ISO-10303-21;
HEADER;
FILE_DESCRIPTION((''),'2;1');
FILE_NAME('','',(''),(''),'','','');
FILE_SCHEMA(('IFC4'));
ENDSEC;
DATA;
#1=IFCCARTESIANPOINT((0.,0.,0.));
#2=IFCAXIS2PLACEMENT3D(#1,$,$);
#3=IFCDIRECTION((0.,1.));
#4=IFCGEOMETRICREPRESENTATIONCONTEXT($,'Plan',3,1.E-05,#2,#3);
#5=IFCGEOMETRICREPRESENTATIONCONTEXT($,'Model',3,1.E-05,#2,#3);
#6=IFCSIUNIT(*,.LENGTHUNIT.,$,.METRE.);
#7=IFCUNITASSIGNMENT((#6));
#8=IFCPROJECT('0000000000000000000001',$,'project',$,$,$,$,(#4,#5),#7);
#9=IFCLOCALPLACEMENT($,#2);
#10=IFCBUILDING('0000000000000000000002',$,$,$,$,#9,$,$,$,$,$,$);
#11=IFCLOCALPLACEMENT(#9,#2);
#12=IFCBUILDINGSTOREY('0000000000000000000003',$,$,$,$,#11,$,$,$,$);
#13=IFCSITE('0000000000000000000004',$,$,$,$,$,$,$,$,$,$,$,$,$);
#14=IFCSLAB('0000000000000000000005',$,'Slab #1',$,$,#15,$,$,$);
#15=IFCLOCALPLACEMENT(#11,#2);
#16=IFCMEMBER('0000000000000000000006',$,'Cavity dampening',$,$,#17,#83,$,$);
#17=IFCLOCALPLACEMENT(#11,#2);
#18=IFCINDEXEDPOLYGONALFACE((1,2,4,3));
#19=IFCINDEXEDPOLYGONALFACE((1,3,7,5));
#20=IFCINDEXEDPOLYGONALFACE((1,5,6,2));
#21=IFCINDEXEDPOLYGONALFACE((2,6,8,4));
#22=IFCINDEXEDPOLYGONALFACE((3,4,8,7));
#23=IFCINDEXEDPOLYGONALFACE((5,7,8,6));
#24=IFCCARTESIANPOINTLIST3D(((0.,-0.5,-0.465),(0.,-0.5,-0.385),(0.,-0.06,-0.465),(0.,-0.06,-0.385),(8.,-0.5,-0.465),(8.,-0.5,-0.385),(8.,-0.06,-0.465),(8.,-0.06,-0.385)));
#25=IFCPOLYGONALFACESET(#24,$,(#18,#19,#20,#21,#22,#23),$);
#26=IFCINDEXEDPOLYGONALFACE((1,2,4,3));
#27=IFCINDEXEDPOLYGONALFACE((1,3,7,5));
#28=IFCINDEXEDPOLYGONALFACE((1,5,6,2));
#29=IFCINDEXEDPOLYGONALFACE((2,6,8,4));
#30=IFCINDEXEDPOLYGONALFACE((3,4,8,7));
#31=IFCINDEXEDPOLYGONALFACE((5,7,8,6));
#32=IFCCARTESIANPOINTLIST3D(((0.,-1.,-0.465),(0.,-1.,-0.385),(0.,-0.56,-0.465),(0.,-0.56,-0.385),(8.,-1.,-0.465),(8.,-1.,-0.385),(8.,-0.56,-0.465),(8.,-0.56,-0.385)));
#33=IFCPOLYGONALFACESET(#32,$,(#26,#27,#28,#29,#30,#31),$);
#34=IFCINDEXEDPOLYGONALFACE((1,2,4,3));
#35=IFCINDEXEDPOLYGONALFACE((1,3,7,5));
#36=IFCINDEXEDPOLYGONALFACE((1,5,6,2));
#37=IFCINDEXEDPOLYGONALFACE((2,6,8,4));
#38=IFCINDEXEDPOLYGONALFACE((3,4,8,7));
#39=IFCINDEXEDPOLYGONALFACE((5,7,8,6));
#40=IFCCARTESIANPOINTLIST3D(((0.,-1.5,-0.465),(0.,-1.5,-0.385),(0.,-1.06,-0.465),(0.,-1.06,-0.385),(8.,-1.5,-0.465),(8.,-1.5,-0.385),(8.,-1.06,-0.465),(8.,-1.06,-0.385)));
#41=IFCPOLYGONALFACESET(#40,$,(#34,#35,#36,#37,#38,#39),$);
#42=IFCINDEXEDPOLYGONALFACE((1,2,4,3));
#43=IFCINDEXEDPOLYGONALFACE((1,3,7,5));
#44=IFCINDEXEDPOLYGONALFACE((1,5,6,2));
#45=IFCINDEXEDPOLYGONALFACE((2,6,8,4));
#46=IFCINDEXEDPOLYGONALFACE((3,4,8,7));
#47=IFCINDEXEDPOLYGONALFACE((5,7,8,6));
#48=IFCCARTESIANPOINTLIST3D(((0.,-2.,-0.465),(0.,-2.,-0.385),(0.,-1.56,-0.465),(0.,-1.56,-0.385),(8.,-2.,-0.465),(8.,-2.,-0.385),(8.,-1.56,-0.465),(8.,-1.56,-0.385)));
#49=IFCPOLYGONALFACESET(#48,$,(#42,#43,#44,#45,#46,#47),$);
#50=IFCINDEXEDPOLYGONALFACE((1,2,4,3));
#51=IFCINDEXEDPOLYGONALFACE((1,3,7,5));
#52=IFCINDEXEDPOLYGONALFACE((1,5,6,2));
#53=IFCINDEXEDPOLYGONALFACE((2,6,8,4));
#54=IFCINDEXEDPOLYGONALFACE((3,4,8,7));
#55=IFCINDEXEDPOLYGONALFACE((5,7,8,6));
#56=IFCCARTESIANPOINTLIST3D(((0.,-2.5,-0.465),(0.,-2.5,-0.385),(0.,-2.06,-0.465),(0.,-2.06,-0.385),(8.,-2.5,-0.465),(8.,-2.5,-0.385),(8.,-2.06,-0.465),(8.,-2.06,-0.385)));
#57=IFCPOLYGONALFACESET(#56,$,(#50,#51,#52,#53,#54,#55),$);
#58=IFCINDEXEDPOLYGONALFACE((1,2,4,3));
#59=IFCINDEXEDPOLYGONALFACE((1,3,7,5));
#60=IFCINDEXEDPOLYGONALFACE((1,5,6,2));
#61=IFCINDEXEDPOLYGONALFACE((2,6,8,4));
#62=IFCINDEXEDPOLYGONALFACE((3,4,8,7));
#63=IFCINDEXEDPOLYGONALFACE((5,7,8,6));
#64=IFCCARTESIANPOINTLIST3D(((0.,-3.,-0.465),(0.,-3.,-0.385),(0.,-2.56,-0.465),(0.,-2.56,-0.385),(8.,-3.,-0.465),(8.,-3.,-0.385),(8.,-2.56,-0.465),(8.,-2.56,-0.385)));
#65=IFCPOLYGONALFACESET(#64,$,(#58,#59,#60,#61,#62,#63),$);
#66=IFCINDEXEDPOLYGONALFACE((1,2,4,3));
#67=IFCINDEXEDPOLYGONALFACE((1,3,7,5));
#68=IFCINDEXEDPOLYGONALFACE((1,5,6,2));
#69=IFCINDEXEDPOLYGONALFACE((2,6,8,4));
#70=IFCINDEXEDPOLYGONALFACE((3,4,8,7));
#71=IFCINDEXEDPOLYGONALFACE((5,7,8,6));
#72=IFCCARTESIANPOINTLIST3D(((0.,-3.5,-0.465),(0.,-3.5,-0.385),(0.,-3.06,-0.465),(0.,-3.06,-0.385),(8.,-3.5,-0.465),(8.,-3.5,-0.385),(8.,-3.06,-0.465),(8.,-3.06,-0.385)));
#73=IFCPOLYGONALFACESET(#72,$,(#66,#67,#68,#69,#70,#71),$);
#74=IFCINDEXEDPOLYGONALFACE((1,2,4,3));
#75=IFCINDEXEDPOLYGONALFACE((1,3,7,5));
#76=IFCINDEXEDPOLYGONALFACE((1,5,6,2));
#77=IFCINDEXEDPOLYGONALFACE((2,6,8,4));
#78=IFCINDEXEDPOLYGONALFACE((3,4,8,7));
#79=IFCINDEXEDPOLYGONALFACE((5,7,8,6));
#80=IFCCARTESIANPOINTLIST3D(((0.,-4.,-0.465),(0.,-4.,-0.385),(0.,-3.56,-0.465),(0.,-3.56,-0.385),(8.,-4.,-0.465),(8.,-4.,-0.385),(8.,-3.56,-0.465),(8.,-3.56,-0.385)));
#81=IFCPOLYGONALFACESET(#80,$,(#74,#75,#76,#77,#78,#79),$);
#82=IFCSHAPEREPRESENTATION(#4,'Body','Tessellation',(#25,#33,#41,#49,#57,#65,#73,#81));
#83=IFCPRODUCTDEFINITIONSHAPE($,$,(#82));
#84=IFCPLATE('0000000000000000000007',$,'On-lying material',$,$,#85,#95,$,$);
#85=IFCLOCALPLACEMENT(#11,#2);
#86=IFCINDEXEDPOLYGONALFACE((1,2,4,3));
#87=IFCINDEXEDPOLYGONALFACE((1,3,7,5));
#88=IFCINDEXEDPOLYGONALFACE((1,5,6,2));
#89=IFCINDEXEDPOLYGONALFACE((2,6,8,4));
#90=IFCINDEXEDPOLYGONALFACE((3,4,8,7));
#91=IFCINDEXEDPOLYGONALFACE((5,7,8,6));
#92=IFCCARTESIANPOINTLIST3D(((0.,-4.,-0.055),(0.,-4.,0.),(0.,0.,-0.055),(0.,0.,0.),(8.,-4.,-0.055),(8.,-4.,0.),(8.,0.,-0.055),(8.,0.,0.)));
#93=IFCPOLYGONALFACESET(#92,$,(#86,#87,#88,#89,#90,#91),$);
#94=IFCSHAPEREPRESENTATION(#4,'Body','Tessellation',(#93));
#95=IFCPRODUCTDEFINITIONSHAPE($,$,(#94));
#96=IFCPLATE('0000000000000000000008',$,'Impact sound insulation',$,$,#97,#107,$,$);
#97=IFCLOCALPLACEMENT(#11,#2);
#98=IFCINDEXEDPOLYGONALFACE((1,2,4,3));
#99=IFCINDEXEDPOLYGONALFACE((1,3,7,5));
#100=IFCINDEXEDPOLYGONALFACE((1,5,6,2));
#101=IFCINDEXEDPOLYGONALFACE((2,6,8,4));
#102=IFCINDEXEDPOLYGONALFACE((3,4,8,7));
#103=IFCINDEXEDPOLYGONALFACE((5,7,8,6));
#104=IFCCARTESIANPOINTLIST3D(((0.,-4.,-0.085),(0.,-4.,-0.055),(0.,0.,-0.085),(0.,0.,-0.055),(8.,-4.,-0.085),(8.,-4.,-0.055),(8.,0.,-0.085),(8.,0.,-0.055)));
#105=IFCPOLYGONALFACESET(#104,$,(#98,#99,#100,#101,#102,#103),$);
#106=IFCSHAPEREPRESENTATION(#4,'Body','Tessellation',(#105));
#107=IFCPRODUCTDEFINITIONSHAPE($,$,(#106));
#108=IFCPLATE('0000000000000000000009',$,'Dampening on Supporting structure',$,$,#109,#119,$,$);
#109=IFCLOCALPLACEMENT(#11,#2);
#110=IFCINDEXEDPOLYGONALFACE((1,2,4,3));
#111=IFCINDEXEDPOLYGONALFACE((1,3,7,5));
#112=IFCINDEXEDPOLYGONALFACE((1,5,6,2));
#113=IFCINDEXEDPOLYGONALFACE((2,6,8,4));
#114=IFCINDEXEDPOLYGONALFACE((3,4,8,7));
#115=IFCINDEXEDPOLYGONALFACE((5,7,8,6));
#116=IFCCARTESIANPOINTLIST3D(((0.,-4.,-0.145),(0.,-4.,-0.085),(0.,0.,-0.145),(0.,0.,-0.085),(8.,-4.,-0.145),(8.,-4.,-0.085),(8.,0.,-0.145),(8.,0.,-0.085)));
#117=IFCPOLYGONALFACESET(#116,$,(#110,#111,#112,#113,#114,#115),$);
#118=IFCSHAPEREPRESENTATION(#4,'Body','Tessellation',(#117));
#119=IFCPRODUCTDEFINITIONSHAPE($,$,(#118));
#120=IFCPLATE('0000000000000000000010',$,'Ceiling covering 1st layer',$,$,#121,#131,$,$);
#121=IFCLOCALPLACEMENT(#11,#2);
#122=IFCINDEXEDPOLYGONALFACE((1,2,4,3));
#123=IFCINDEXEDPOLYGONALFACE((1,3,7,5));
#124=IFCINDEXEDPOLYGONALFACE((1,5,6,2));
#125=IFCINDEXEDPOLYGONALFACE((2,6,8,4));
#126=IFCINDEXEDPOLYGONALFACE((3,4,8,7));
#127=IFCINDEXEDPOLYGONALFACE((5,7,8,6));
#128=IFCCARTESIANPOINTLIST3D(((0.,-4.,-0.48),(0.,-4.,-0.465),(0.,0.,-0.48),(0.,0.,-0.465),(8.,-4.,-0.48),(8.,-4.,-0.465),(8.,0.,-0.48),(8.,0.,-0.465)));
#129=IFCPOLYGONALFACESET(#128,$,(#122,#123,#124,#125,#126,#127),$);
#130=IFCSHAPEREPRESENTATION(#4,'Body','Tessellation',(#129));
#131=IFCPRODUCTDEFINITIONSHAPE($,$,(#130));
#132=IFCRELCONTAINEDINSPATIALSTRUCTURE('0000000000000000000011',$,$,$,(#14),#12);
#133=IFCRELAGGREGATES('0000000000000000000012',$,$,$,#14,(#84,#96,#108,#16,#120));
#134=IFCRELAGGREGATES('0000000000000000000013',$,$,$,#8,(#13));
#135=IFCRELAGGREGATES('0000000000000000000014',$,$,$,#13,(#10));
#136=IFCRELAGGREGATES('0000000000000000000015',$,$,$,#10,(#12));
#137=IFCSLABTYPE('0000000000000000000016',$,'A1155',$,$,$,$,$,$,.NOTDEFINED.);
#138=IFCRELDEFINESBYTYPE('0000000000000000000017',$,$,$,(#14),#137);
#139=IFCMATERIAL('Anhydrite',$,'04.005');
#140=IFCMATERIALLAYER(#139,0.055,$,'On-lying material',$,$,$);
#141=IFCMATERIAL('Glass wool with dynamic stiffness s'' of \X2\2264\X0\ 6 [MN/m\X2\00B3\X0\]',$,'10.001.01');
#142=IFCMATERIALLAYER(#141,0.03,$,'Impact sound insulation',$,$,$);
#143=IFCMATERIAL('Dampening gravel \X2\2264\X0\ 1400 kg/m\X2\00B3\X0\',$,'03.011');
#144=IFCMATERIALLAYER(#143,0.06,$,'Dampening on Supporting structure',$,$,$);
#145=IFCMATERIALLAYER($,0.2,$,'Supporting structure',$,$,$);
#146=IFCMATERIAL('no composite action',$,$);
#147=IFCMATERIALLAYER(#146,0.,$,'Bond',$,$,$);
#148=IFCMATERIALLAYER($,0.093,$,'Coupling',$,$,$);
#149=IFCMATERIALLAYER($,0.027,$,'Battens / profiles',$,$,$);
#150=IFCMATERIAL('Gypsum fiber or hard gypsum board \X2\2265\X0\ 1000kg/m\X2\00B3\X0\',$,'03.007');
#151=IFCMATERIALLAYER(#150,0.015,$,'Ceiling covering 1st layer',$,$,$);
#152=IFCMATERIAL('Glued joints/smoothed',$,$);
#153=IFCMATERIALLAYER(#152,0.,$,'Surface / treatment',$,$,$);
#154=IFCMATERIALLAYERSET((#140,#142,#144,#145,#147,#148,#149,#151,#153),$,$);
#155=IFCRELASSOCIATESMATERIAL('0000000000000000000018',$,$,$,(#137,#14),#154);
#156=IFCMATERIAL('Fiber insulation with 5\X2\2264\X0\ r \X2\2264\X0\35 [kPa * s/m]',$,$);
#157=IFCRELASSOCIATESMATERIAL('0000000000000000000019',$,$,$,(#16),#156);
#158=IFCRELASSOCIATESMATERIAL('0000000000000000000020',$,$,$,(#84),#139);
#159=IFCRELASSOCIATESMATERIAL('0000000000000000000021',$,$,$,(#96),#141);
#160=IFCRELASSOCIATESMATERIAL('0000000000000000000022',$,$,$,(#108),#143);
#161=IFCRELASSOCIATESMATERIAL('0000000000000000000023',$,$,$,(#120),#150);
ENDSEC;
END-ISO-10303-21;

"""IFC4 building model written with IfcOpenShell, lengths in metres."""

from ifc_helpers import new_model, si_unit, direction, frame, frame_2d, origin, origin_with_axes, place, context, project, spatial, rectangle, extrude, material, layer, layer_set, type_object, element, aggregate, save


model = new_model("IFC4")

# Units and contexts
plan_context = context("Plan", 3, precision=1e-05, world=origin(), true_north=direction((0.0, 1.0)))
model_context = context("Model", 3, precision=1e-05, world=origin(), true_north=direction((0.0, 1.0)))
ifc_project = project(units=[si_unit("LENGTHUNIT", "METRE")], contexts=[plan_context, model_context])

# Site, building, storey
site = spatial("IfcSite", under=ifc_project)
building_placement = place(None, origin())
building = spatial("IfcBuilding", under=site, at=building_placement)
storey_placement = place(building_placement, origin())
storey = spatial("IfcBuildingStorey", under=building, at=storey_placement)

# Slab, member, plates
ifc_material_1 = material(Name="Anhydrite", Category="04.005")
ifc_layer_1 = layer(ifc_material_1, 0.055, Name="On-lying material")
ifc_material_2 = material(Name="Glass wool with dynamic stiffness s' of ≤ 6 [MN/m³]", Category="10.001.01")
ifc_layer_2 = layer(ifc_material_2, 0.03, Name="Impact sound insulation")
ifc_material_3 = material(Name="Dampening gravel ≤ 1400 kg/m³", Category="03.011")
ifc_layer_3 = layer(ifc_material_3, 0.06, Name="Dampening on Supporting structure")
ifc_layer_4 = layer(None, 0.2, Name="Supporting structure")
ifc_material_4 = material(Name="no composite action")
ifc_layer_5 = layer(ifc_material_4, 0.0, Name="Bond")
ifc_layer_6 = layer(None, 0.093, Name="Coupling")
ifc_layer_7 = layer(None, 0.027, Name="Battens / profiles")
ifc_material_5 = material(Name="Gypsum fiber or hard gypsum board ≥ 1000kg/m³", Category="03.007")
ifc_layer_8 = layer(ifc_material_5, 0.015, Name="Ceiling covering 1st layer")
ifc_material_6 = material(Name="Glued joints/smoothed")
ifc_layer_9 = layer(ifc_material_6, 0.0, Name="Surface / treatment")
ifc_layer_set = layer_set([ifc_layer_1, ifc_layer_2, ifc_layer_3, ifc_layer_4, ifc_layer_5, ifc_layer_6, ifc_layer_7, ifc_layer_8, ifc_layer_9])
slab_type = type_object("IfcSlabType", Name="A1155", PredefinedType="NOTDEFINED", material=ifc_layer_set)
slab_placement = place(None, frame((0.0, 0.0, 0.0), z_axis=(0.0, 0.0, -1.0), x_axis=(1.0, 0.0, 0.0)))
slab = element("IfcSlab", 1, at=slab_placement, inside=storey, type_object=slab_type, material=ifc_layer_set, Name="Slab #1")
ifc_material_7 = material(Name="Fiber insulation with 5≤ r ≤35 [kPa * s/m]")
member_1_placement = place(slab_placement, origin())
member_1 = element("IfcMember", 2, at=member_1_placement, material=ifc_material_7, Name="Cavity dampening", context=plan_context, shape_type="SweptSolid", body=[
    extrude(rectangle(XDim=0.44, YDim=0.08, at=frame_2d((0.22, 0.04), x_axis=(1.0, 0.0))), frame((0.0, 0.06, 0.385), z_axis=(1.0, 0.0, 0.0), x_axis=(0.0, 1.0, 0.0)), (0.0, 0.0, 1.0), 8.0),
    extrude(rectangle(XDim=0.44, YDim=0.08, at=frame_2d((0.22, 0.04), x_axis=(1.0, 0.0))), frame((0.0, 0.56, 0.385), z_axis=(1.0, 0.0, 0.0), x_axis=(0.0, 1.0, 0.0)), (0.0, 0.0, 1.0), 8.0),
    extrude(rectangle(XDim=0.44, YDim=0.08, at=frame_2d((0.22, 0.04), x_axis=(1.0, 0.0))), frame((0.0, 1.06, 0.385), z_axis=(1.0, 0.0, 0.0), x_axis=(0.0, 1.0, 0.0)), (0.0, 0.0, 1.0), 8.0),
    extrude(rectangle(XDim=0.44, YDim=0.08, at=frame_2d((0.22, 0.04), x_axis=(1.0, 0.0))), frame((0.0, 1.56, 0.385), z_axis=(1.0, 0.0, 0.0), x_axis=(0.0, 1.0, 0.0)), (0.0, 0.0, 1.0), 8.0),
    extrude(rectangle(XDim=0.44, YDim=0.08, at=frame_2d((0.22, 0.04), x_axis=(1.0, 0.0))), frame((0.0, 2.06, 0.385), z_axis=(1.0, 0.0, 0.0), x_axis=(0.0, 1.0, 0.0)), (0.0, 0.0, 1.0), 8.0),
    extrude(rectangle(XDim=0.44, YDim=0.08, at=frame_2d((0.22, 0.04), x_axis=(1.0, 0.0))), frame((0.0, 2.56, 0.385), z_axis=(1.0, 0.0, 0.0), x_axis=(0.0, 1.0, 0.0)), (0.0, 0.0, 1.0), 8.0),
    extrude(rectangle(XDim=0.44, YDim=0.08, at=frame_2d((0.22, 0.04), x_axis=(1.0, 0.0))), frame((0.0, 3.06, 0.385), z_axis=(1.0, 0.0, 0.0), x_axis=(0.0, 1.0, 0.0)), (0.0, 0.0, 1.0), 8.0),
    extrude(rectangle(XDim=0.44, YDim=0.08, at=frame_2d((0.22, 0.04), x_axis=(1.0, 0.0))), frame((0.0, 3.56, 0.385), z_axis=(1.0, 0.0, 0.0), x_axis=(0.0, 1.0, 0.0)), (0.0, 0.0, 1.0), 8.0),
])
plate_1_placement = place(slab_placement, origin())
plate_1 = element("IfcPlate", 3, at=plate_1_placement, material=ifc_material_1, Name="On-lying material", context=plan_context, shape_type="SweptSolid", body=[
    extrude(rectangle(XDim=8.0, YDim=4.0, at=frame_2d((4.0, 2.0), x_axis=(1.0, 0.0))), origin_with_axes(), (0.0, 0.0, 1.0), 0.055),
])
plate_2_placement = place(slab_placement, origin())
plate_2 = element("IfcPlate", 4, at=plate_2_placement, material=ifc_material_2, Name="Impact sound insulation", context=plan_context, shape_type="SweptSolid", body=[
    extrude(rectangle(XDim=8.0, YDim=4.0, at=frame_2d((4.0, 2.0), x_axis=(1.0, 0.0))), frame((0.0, 0.0, 0.055), z_axis=(0.0, 0.0, 1.0), x_axis=(1.0, 0.0, 0.0)), (0.0, 0.0, 1.0), 0.03),
])
plate_3_placement = place(slab_placement, origin())
plate_3 = element("IfcPlate", 5, at=plate_3_placement, material=ifc_material_3, Name="Dampening on Supporting structure", context=plan_context, shape_type="SweptSolid", body=[
    extrude(rectangle(XDim=8.0, YDim=4.0, at=frame_2d((4.0, 2.0), x_axis=(1.0, 0.0))), frame((0.0, 0.0, 0.085), z_axis=(0.0, 0.0, 1.0), x_axis=(1.0, 0.0, 0.0)), (0.0, 0.0, 1.0), 0.06),
])
plate_4_placement = place(slab_placement, origin())
plate_4 = element("IfcPlate", 6, at=plate_4_placement, material=ifc_material_5, Name="Ceiling covering 1st layer", context=plan_context, shape_type="SweptSolid", body=[
    extrude(rectangle(XDim=8.0, YDim=4.0, at=frame_2d((4.0, 2.0), x_axis=(1.0, 0.0))), frame((0.0, 0.0, 0.465), z_axis=(0.0, 0.0, 1.0), x_axis=(1.0, 0.0, 0.0)), (0.0, 0.0, 1.0), 0.015),
])
aggregate(slab, [plate_1, plate_2, plate_3, member_1, plate_4])

save(model, "model.ifc")
